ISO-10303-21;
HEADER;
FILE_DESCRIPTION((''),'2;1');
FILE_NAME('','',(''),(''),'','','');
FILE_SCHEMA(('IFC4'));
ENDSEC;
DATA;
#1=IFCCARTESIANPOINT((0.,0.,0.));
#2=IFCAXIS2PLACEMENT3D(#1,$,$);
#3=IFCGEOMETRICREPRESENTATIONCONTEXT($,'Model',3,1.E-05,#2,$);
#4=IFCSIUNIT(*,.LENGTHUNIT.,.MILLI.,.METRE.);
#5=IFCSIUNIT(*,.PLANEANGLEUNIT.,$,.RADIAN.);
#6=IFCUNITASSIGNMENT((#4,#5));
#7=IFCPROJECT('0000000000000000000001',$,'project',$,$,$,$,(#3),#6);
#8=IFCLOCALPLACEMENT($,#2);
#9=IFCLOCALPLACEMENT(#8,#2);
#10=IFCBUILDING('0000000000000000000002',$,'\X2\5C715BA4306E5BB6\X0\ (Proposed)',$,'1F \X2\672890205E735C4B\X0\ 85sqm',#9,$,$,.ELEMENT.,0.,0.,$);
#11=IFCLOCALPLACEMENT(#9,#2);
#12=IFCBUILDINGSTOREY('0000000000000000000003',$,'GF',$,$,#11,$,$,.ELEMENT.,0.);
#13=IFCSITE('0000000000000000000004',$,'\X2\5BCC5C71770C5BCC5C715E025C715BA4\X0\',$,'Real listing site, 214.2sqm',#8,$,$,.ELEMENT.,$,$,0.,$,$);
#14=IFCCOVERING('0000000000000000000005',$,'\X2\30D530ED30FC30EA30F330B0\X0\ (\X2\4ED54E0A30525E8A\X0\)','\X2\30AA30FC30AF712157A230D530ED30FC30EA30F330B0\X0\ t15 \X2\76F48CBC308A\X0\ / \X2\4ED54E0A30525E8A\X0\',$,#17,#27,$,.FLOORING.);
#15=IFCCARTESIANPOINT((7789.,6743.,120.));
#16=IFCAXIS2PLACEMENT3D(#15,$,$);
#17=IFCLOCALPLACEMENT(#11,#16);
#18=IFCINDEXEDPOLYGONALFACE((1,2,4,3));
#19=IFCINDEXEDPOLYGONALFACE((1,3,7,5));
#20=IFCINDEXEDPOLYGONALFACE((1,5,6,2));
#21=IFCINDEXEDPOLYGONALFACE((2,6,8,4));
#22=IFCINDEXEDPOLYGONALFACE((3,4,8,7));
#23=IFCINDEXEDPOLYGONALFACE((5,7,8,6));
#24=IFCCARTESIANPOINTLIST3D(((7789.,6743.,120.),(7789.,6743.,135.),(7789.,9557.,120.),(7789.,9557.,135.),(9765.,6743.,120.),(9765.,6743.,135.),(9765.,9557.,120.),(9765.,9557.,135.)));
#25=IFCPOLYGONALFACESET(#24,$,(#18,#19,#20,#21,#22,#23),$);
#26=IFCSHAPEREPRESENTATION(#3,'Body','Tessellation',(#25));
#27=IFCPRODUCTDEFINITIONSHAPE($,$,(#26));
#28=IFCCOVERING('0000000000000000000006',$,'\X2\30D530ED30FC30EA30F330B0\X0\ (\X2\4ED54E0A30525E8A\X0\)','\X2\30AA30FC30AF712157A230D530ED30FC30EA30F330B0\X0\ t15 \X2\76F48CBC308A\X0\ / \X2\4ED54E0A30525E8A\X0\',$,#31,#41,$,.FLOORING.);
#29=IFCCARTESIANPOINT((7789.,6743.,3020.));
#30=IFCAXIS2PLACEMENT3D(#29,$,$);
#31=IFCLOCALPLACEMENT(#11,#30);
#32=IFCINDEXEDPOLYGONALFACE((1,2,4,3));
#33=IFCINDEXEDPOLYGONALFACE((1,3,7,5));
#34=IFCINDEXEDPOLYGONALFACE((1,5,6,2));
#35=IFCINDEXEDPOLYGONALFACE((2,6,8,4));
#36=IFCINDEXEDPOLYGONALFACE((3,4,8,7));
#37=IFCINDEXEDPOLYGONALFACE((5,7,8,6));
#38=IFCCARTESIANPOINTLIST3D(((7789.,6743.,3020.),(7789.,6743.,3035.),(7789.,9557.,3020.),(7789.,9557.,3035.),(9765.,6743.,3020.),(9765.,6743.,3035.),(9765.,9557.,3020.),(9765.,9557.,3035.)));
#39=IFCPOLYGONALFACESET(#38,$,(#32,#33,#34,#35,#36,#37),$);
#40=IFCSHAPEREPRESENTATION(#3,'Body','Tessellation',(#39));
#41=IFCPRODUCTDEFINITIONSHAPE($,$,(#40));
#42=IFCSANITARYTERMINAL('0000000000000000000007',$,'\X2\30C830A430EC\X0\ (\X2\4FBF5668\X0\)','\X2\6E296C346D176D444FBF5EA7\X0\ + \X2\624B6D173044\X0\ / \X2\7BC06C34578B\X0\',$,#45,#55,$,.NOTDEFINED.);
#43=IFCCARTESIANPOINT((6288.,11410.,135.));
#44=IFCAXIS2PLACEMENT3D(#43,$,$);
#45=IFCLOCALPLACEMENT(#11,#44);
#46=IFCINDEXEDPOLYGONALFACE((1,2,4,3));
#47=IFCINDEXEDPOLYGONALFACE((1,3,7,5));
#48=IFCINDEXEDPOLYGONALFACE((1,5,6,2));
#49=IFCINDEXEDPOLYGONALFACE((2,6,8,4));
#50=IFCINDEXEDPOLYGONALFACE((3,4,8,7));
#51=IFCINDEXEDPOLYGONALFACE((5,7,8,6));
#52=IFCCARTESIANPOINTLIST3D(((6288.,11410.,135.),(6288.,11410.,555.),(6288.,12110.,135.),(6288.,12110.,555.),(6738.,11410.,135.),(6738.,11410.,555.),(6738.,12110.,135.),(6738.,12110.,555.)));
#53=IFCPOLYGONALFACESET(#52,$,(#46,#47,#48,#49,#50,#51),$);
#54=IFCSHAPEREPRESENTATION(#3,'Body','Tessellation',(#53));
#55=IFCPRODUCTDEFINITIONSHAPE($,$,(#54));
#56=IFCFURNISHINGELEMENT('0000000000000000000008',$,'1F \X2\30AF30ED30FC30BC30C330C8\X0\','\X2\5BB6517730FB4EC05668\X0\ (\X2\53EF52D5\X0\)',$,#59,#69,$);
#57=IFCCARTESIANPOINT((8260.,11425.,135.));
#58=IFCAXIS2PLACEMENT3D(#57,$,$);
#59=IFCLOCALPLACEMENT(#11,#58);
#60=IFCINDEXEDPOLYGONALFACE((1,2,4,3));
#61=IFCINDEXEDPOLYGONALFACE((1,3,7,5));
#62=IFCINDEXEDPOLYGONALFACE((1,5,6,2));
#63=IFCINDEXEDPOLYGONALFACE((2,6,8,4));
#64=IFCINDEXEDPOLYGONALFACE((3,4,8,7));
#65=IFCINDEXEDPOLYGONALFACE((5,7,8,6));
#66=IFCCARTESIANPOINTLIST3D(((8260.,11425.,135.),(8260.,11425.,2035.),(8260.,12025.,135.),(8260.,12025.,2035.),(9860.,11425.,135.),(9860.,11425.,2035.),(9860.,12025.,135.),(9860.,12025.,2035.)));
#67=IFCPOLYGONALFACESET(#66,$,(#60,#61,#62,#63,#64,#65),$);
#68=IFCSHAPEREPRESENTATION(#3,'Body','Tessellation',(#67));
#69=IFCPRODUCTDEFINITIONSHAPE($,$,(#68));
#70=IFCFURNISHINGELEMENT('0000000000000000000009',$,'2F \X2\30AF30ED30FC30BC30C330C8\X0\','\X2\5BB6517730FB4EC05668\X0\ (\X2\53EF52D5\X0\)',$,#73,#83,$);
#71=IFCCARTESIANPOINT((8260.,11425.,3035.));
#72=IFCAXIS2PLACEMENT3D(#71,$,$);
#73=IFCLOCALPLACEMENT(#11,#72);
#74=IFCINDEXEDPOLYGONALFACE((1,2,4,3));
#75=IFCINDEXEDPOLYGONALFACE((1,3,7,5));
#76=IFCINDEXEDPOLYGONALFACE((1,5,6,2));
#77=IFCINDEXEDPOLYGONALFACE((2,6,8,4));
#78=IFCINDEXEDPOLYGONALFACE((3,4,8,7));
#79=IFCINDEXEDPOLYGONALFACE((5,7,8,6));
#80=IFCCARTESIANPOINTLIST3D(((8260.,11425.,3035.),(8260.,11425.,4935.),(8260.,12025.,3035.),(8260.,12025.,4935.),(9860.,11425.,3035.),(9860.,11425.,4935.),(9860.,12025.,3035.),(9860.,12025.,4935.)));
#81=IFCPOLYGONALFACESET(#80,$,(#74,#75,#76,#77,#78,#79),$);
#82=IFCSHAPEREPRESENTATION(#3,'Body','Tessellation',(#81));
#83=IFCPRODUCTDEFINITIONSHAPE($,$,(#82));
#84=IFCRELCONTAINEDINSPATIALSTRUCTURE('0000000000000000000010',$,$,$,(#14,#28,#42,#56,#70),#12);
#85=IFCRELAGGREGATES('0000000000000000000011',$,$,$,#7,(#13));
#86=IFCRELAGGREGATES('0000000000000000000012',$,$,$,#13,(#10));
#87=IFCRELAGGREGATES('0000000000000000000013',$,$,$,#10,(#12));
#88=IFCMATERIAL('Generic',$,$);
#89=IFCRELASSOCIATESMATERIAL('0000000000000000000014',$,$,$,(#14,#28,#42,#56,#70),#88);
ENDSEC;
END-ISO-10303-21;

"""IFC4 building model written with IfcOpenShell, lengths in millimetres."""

from ifc_helpers import new_model, si_unit, frame, frame_2d, origin, place, context, project, spatial, rectangle, extrude, material, element, save


model = new_model("IFC4")

# Units and contexts
model_context = context("Model", 3, precision=1e-05, world=origin())
ifc_project = project(units=[si_unit("LENGTHUNIT", "METRE", prefix="MILLI"), si_unit("PLANEANGLEUNIT", "RADIAN")], contexts=[model_context])

# Site, building, storey
site_placement = place(None, origin())
site = spatial("IfcSite", under=ifc_project, at=site_placement, Name="富山県富山市山室", ObjectType="Real listing site, 214.2sqm", CompositionType="ELEMENT", RefElevation=0.0)
building_placement = place(site_placement, origin())
building = spatial("IfcBuilding", under=site, at=building_placement, Name="山室の家 (Proposed)", ObjectType="1F 木造平屋 85sqm", CompositionType="ELEMENT", ElevationOfRefHeight=0.0, ElevationOfTerrain=0.0)
storey_placement = place(building_placement, origin())
storey = spatial("IfcBuildingStorey", under=building, at=storey_placement, Name="GF", CompositionType="ELEMENT", Elevation=0.0)

# Shared definitions
ifc_material_1 = material(Name="Generic")

# Coverings
covering_1_placement = place(storey_placement, frame((7789.0, 6743.0, 120.0)))
element("IfcCovering", 1, at=covering_1_placement, inside=storey, material=ifc_material_1, Name="フローリング (仕上げ床)", Description="オーク無垢フローリング t15 直貼り / 仕上げ床", PredefinedType="FLOORING", context=model_context, shape_type="SweptSolid", body=[
    extrude(rectangle(XDim=1976.0, YDim=2814.0, at=frame_2d((988.0, 1407.0))), frame((7789.0, 6743.0, 120.0)), (0.0, 0.0, 1.0), 15.0),
])
covering_2_placement = place(storey_placement, frame((7789.0, 6743.0, 3020.0)))
element("IfcCovering", 2, at=covering_2_placement, inside=storey, material=ifc_material_1, Name="フローリング (仕上げ床)", Description="オーク無垢フローリング t15 直貼り / 仕上げ床", PredefinedType="FLOORING", context=model_context, shape_type="SweptSolid", body=[
    extrude(rectangle(XDim=1976.0, YDim=2814.0, at=frame_2d((988.0, 1407.0))), frame((7789.0, 6743.0, 3020.0)), (0.0, 0.0, 1.0), 15.0),
])

# Sanitary terminal
sanitary_terminal_placement = place(storey_placement, frame((6288.0, 11410.0, 135.0)))
element("IfcSanitaryTerminal", 3, at=sanitary_terminal_placement, inside=storey, material=ifc_material_1, Name="トイレ (便器)", Description="温水洗浄便座 + 手洗い / 節水型", PredefinedType="NOTDEFINED", context=model_context, shape_type="SweptSolid", body=[
    extrude(rectangle(XDim=450.0, YDim=700.0, at=frame_2d((225.0, 350.0))), frame((6288.0, 11410.0, 135.0)), (0.0, 0.0, 1.0), 420.0),
])

# Furnishing elements
furnishing_1_placement = place(storey_placement, frame((8260.0, 11425.0, 135.0)))
element("IfcFurnishingElement", 4, at=furnishing_1_placement, inside=storey, material=ifc_material_1, Name="1F クローゼット", Description="家具・什器 (可動)", context=model_context, shape_type="SweptSolid", body=[
    extrude(rectangle(XDim=1600.0, YDim=600.0, at=frame_2d((800.0, 300.0))), frame((8260.0, 11425.0, 135.0)), (0.0, 0.0, 1.0), 1900.0),
])
furnishing_2_placement = place(storey_placement, frame((8260.0, 11425.0, 3035.0)))
element("IfcFurnishingElement", 5, at=furnishing_2_placement, inside=storey, material=ifc_material_1, Name="2F クローゼット", Description="家具・什器 (可動)", context=model_context, shape_type="SweptSolid", body=[
    extrude(rectangle(XDim=1600.0, YDim=600.0, at=frame_2d((800.0, 300.0))), frame((8260.0, 11425.0, 3035.0)), (0.0, 0.0, 1.0), 1900.0),
])

save(model, "model.ifc")
